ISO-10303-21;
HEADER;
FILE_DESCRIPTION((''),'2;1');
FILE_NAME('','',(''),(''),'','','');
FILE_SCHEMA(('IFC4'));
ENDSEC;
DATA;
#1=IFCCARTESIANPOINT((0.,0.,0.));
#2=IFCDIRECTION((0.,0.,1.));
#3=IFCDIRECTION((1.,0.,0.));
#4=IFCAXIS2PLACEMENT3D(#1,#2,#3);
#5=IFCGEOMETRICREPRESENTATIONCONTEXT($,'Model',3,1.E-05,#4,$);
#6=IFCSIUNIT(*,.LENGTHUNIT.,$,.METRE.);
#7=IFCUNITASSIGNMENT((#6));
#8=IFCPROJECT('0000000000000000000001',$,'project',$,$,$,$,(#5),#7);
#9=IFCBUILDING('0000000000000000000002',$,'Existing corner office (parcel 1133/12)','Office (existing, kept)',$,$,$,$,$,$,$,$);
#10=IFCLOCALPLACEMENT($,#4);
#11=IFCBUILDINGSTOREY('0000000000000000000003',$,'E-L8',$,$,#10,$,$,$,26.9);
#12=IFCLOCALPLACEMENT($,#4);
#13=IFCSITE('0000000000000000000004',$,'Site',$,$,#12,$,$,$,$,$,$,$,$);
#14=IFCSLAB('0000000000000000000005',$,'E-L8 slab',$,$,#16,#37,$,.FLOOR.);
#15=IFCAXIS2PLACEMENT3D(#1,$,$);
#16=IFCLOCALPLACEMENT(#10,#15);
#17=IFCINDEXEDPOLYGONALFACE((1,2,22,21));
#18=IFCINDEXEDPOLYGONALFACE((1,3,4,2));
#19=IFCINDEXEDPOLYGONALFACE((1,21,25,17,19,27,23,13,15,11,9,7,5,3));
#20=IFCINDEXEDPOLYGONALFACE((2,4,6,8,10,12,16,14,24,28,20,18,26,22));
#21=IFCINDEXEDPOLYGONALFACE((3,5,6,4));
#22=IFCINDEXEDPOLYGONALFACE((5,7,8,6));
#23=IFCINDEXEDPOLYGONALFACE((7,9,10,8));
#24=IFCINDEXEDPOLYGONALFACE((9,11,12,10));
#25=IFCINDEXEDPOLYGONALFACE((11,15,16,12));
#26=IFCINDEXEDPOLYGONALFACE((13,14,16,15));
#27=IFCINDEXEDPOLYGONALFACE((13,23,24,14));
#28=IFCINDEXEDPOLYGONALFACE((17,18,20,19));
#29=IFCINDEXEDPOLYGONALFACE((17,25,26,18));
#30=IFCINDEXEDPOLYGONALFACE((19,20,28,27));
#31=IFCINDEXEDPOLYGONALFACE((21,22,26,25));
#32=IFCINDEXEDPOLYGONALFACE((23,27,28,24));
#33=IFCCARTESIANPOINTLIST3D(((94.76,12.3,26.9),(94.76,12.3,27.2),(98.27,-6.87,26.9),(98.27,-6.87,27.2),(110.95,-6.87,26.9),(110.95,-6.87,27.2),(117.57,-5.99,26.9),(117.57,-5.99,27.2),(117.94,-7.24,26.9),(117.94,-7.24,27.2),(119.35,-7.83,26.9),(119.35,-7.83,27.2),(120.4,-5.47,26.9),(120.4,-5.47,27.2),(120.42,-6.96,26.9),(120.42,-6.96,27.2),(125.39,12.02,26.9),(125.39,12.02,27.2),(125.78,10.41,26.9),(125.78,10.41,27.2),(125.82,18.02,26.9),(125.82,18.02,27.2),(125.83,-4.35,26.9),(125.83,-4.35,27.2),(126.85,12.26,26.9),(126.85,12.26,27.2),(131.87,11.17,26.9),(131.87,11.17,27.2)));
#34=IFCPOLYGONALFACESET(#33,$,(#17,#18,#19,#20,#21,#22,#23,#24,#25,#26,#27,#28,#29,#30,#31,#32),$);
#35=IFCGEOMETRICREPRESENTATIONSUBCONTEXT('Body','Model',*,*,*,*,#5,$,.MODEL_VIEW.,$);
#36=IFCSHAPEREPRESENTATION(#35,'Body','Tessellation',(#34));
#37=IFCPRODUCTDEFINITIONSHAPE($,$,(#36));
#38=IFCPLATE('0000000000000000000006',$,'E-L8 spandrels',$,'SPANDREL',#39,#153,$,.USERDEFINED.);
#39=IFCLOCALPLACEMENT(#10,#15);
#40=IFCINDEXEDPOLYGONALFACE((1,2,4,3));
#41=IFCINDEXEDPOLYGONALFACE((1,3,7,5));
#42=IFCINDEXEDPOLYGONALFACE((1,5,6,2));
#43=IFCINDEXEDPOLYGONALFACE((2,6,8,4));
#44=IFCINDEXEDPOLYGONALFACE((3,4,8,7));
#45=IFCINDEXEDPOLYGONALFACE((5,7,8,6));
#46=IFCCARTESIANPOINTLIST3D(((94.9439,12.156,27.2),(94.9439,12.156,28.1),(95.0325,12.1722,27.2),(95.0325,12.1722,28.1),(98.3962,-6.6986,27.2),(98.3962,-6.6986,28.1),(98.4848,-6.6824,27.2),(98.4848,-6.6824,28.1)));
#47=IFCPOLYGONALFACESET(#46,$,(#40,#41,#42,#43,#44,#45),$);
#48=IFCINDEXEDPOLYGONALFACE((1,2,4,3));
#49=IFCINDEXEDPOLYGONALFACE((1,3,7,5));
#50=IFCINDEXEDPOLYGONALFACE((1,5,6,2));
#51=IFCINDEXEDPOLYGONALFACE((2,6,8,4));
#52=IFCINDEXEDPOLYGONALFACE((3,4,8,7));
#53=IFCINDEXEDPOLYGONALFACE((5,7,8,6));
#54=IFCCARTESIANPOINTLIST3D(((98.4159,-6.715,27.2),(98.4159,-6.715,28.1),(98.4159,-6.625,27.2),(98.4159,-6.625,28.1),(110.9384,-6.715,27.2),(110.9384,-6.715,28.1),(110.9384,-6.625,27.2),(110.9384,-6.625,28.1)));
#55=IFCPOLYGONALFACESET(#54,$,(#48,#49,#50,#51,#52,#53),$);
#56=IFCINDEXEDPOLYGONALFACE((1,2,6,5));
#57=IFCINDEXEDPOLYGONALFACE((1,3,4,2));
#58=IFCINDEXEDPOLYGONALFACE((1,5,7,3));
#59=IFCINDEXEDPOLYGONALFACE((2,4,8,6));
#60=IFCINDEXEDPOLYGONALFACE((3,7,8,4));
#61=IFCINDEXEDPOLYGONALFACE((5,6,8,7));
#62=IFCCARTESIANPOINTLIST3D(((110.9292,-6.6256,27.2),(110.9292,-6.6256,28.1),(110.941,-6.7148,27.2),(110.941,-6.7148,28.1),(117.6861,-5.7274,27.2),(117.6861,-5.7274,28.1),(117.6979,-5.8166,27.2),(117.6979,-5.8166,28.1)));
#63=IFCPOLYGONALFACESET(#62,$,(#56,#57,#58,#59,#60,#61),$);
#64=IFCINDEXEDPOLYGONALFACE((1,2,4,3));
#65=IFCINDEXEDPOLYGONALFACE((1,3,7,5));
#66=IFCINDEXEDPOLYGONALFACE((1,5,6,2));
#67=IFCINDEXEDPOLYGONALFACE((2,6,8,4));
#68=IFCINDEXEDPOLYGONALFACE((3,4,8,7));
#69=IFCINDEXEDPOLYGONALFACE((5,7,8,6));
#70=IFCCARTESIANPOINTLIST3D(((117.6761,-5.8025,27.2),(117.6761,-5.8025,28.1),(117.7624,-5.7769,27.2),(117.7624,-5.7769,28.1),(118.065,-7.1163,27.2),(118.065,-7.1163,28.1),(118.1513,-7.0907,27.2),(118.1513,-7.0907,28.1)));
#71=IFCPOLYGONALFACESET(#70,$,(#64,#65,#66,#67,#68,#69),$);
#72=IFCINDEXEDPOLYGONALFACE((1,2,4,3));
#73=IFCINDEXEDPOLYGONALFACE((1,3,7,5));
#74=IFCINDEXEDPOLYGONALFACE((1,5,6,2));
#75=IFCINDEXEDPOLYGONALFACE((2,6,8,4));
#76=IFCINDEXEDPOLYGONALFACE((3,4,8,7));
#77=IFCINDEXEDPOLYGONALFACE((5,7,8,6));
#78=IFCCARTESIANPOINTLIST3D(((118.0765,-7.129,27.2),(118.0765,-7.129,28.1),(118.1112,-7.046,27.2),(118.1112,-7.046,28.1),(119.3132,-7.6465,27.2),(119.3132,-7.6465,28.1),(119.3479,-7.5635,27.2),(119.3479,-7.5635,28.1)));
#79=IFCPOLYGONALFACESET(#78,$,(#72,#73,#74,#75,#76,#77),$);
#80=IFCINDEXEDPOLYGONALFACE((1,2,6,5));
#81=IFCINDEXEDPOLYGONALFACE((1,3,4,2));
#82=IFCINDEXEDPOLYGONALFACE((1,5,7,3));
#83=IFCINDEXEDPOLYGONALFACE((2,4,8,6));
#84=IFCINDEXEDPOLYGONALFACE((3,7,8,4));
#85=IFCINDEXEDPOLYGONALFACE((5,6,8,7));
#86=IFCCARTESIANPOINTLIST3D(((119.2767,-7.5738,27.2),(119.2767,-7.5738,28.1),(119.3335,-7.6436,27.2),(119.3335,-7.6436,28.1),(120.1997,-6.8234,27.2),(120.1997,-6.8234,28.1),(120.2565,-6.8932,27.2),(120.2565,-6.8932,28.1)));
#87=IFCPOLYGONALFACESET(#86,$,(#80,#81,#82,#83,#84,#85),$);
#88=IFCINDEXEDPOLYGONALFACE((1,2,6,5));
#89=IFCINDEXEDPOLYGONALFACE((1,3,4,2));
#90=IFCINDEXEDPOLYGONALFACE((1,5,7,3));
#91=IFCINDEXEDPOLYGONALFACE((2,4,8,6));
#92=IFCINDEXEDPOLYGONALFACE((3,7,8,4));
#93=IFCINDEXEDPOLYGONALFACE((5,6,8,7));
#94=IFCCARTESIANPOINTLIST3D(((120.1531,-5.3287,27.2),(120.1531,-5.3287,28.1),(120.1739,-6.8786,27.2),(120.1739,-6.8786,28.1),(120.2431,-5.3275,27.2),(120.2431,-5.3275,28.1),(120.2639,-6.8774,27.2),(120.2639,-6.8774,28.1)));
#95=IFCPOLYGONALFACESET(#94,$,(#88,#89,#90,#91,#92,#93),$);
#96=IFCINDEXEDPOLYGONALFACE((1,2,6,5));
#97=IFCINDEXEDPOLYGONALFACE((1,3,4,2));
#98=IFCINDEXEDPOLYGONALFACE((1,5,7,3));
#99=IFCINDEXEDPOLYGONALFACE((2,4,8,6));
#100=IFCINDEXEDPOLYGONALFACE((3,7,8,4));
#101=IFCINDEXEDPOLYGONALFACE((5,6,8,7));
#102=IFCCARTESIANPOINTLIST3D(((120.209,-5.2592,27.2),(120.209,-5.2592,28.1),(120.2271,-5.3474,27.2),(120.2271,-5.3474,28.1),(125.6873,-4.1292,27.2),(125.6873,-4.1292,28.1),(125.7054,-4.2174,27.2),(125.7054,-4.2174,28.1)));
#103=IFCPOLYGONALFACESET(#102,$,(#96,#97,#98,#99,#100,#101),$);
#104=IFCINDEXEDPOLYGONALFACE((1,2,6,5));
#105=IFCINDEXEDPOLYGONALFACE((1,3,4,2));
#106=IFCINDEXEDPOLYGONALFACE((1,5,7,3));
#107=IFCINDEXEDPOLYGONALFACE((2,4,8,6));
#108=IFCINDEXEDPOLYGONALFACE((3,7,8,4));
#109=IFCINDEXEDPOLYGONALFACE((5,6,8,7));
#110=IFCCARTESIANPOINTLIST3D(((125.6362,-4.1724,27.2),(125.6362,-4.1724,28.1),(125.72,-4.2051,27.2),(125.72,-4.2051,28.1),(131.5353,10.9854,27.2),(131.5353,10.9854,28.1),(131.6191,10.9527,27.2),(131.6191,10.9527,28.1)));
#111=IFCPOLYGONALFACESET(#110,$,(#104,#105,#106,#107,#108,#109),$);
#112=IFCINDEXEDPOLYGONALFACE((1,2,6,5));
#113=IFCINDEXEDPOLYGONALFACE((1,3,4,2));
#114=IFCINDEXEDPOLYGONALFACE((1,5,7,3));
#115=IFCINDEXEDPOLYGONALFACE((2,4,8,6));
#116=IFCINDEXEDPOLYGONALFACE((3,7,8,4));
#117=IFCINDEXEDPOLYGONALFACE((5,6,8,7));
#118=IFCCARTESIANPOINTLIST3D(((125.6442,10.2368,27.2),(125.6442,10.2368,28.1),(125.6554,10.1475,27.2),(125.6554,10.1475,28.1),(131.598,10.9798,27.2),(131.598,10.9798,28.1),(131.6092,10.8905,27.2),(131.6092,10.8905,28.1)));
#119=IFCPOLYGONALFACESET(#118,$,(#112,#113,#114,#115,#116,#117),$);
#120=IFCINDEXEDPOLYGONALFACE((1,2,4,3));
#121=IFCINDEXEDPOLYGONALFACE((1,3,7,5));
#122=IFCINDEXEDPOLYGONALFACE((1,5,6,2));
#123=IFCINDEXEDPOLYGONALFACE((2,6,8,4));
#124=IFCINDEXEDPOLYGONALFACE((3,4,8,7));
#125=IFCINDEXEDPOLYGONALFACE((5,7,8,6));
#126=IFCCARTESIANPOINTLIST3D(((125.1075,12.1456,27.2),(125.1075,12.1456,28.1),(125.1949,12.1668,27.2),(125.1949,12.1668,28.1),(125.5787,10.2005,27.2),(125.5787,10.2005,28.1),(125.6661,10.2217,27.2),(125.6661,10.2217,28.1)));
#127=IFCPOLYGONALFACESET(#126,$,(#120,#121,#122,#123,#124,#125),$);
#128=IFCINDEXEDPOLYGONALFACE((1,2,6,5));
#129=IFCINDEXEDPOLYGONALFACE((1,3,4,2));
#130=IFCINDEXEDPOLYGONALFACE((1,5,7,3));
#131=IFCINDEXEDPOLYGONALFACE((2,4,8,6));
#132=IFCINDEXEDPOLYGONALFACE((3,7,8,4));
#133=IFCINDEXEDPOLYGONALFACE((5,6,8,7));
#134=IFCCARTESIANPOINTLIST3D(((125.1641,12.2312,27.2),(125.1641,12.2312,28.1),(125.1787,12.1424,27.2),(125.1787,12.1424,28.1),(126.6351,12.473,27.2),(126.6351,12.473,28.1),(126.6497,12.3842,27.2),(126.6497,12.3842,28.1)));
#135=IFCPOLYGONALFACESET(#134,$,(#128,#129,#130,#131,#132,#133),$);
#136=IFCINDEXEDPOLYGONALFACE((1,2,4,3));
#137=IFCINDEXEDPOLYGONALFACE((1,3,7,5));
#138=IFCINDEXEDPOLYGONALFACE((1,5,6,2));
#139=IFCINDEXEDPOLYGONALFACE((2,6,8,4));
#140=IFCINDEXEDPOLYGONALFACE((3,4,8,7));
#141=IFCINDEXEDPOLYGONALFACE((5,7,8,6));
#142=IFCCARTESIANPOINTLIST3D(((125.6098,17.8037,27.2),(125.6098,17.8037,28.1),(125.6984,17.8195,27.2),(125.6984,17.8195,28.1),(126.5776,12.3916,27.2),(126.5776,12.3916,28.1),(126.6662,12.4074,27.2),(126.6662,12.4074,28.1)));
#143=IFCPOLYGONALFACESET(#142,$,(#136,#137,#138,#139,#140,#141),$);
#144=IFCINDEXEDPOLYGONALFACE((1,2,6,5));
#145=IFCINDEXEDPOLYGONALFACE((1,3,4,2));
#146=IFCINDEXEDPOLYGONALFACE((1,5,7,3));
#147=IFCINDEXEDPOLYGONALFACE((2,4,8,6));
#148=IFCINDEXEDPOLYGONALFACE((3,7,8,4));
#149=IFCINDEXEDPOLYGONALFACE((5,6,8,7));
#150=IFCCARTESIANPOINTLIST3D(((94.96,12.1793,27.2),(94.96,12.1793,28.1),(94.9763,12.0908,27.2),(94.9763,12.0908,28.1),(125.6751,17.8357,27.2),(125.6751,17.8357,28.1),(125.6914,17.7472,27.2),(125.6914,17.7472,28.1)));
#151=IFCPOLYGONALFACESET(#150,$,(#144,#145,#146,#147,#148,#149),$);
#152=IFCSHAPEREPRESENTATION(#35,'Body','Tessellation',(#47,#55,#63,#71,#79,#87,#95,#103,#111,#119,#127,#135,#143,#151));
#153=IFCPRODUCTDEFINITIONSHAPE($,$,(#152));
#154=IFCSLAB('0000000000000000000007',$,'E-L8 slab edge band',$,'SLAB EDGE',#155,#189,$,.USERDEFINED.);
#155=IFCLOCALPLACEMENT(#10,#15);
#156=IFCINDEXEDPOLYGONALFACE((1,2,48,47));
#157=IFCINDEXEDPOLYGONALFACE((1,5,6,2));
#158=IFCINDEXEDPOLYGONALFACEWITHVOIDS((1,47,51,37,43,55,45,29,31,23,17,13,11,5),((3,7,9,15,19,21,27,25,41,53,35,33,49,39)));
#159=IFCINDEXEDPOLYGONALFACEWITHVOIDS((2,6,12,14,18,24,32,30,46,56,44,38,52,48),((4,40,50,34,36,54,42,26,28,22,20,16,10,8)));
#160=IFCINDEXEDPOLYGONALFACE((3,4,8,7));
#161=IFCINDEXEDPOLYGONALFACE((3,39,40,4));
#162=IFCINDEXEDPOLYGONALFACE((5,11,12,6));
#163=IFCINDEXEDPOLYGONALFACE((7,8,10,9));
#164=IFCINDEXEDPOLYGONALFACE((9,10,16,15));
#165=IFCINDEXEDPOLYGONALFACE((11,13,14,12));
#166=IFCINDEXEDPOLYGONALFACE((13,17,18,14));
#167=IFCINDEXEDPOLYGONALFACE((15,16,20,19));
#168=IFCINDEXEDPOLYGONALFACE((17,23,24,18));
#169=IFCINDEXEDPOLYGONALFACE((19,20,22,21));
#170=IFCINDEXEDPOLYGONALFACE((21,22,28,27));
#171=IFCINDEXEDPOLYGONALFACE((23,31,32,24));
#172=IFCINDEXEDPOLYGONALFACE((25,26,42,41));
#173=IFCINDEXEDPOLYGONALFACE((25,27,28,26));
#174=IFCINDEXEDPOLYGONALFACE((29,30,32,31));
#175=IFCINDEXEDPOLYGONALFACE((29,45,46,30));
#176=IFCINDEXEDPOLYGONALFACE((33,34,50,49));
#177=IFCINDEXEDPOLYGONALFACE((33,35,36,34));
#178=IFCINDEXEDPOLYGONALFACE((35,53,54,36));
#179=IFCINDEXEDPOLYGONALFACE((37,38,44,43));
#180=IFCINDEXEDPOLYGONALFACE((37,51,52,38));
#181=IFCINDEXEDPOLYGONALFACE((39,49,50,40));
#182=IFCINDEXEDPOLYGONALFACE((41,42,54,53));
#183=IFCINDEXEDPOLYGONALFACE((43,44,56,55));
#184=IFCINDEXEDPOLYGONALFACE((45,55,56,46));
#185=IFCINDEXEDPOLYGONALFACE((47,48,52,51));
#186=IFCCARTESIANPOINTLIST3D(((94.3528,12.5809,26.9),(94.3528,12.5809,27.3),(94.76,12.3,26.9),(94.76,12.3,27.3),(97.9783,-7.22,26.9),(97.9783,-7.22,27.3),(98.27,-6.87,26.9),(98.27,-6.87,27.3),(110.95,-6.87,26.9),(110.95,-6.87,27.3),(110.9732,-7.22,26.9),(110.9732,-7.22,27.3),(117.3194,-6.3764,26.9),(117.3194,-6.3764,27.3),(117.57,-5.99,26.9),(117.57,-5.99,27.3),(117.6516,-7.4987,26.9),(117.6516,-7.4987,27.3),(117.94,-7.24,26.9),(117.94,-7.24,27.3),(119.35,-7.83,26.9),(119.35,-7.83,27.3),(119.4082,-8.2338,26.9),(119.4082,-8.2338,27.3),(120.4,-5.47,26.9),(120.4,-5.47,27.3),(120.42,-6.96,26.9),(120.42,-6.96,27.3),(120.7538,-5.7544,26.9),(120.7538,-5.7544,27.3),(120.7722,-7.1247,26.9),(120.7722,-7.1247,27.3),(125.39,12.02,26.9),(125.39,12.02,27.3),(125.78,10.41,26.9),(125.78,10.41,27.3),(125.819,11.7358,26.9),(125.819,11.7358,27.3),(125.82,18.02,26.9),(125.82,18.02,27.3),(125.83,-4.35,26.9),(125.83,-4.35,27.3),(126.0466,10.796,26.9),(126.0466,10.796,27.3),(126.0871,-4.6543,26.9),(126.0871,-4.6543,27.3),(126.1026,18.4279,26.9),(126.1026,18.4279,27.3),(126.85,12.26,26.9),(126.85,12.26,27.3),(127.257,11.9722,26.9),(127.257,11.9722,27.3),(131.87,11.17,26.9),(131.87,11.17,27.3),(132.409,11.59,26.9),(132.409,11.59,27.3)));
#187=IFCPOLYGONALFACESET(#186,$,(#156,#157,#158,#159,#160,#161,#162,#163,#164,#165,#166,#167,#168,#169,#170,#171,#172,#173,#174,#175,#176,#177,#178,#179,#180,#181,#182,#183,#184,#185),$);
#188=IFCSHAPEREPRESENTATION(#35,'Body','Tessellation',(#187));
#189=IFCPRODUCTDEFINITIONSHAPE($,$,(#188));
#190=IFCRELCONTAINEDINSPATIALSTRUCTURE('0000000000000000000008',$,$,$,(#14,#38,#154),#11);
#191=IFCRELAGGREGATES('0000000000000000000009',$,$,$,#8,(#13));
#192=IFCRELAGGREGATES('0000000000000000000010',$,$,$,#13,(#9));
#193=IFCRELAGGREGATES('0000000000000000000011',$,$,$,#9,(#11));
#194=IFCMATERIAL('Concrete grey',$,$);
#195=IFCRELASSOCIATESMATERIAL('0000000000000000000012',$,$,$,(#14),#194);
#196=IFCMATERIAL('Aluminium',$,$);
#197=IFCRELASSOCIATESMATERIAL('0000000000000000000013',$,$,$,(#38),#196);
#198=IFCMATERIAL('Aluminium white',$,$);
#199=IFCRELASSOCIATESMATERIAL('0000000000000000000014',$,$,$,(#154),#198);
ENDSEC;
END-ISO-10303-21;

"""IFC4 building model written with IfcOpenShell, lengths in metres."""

from ifc_helpers import new_model, si_unit, frame, origin_with_axes, place, context, subcontext, project, spatial, polyline, outline, extrude, material, element, save


model = new_model("IFC4")

# Units and contexts
model_context = context("Model", 3, precision=1e-05, world=origin_with_axes())
body_context = subcontext(model_context, "Body", "Model", "MODEL_VIEW")
ifc_project = project(units=[si_unit("LENGTHUNIT", "METRE")], contexts=[model_context])

# Site, building, storey
site_placement = place(None, origin_with_axes())
site = spatial("IfcSite", under=ifc_project, at=site_placement, Name="Site")
building = spatial("IfcBuilding", under=site, Name="Existing corner office (parcel 1133/12)", Description="Office (existing, kept)")
storey_placement = place(None, origin_with_axes())
storey = spatial("IfcBuildingStorey", under=building, at=storey_placement, Name="E-L8", Elevation=26.9)

# Shared definitions
ifc_material_1 = material(Name="Aluminium")

# Slab
ifc_material_2 = material(Name="Concrete grey")
slab_1_placement = place(storey_placement, origin_with_axes())
element("IfcSlab", 1, at=slab_1_placement, inside=storey, material=ifc_material_2, Name="E-L8 slab", PredefinedType="FLOOR", context=body_context, shape_type="SweptSolid", body=[
    extrude(outline(polyline([(94.76, 12.3), (98.27, -6.87), (110.95, -6.87), (117.57, -5.99), (117.94, -7.24), (119.35, -7.83), (120.42, -6.96), (120.4, -5.47), (125.83, -4.35), (131.87, 11.17), (125.78, 10.41), (125.39, 12.02), (126.85, 12.26), (125.82, 18.02), (94.76, 12.3)])), frame((0.0, 0.0, 26.9), z_axis=(0.0, 0.0, 1.0), x_axis=(1.0, 0.0, 0.0)), (0.0, 0.0, 1.0), 0.3),
])

# Plate
plate_placement = place(storey_placement, origin_with_axes())
element("IfcPlate", 2, at=plate_placement, inside=storey, material=ifc_material_1, Name="E-L8 spandrels", ObjectType="SPANDREL", PredefinedType="USERDEFINED", context=body_context, shape_type="SweptSolid", body=[
    extrude(outline(polyline([(94.9439, 12.156), (98.3962, -6.6986), (98.4848, -6.6824), (95.0325, 12.1722), (94.9439, 12.156)])), frame((0.0, 0.0, 27.2), z_axis=(0.0, 0.0, 1.0), x_axis=(1.0, 0.0, 0.0)), (0.0, 0.0, 1.0), 0.9),
    extrude(outline(polyline([(98.4159, -6.715), (110.9384, -6.715), (110.9384, -6.625), (98.4159, -6.625), (98.4159, -6.715)])), frame((0.0, 0.0, 27.2), z_axis=(0.0, 0.0, 1.0), x_axis=(1.0, 0.0, 0.0)), (0.0, 0.0, 1.0), 0.9),
    extrude(outline(polyline([(110.941, -6.7148), (117.6979, -5.8166), (117.6861, -5.7274), (110.9292, -6.6256), (110.941, -6.7148)])), frame((0.0, 0.0, 27.2), z_axis=(0.0, 0.0, 1.0), x_axis=(1.0, 0.0, 0.0)), (0.0, 0.0, 1.0), 0.9),
    extrude(outline(polyline([(117.6761, -5.8025), (118.065, -7.1163), (118.1513, -7.0907), (117.7624, -5.7769), (117.6761, -5.8025)])), frame((0.0, 0.0, 27.2), z_axis=(0.0, 0.0, 1.0), x_axis=(1.0, 0.0, 0.0)), (0.0, 0.0, 1.0), 0.9),
    extrude(outline(polyline([(118.0765, -7.129), (119.3132, -7.6465), (119.3479, -7.5635), (118.1112, -7.046), (118.0765, -7.129)])), frame((0.0, 0.0, 27.2), z_axis=(0.0, 0.0, 1.0), x_axis=(1.0, 0.0, 0.0)), (0.0, 0.0, 1.0), 0.9),
    extrude(outline(polyline([(119.3335, -7.6436), (120.2565, -6.8932), (120.1997, -6.8234), (119.2767, -7.5738), (119.3335, -7.6436)])), frame((0.0, 0.0, 27.2), z_axis=(0.0, 0.0, 1.0), x_axis=(1.0, 0.0, 0.0)), (0.0, 0.0, 1.0), 0.9),
    extrude(outline(polyline([(120.2639, -6.8774), (120.2431, -5.3275), (120.1531, -5.3287), (120.1739, -6.8786), (120.2639, -6.8774)])), frame((0.0, 0.0, 27.2), z_axis=(0.0, 0.0, 1.0), x_axis=(1.0, 0.0, 0.0)), (0.0, 0.0, 1.0), 0.9),
    extrude(outline(polyline([(120.2271, -5.3474), (125.7054, -4.2174), (125.6873, -4.1292), (120.209, -5.2592), (120.2271, -5.3474)])), frame((0.0, 0.0, 27.2), z_axis=(0.0, 0.0, 1.0), x_axis=(1.0, 0.0, 0.0)), (0.0, 0.0, 1.0), 0.9),
    extrude(outline(polyline([(125.72, -4.2051), (131.6191, 10.9527), (131.5353, 10.9854), (125.6362, -4.1724), (125.72, -4.2051)])), frame((0.0, 0.0, 27.2), z_axis=(0.0, 0.0, 1.0), x_axis=(1.0, 0.0, 0.0)), (0.0, 0.0, 1.0), 0.9),
    extrude(outline(polyline([(131.598, 10.9798), (125.6442, 10.2368), (125.6554, 10.1475), (131.6092, 10.8905), (131.598, 10.9798)])), frame((0.0, 0.0, 27.2), z_axis=(0.0, 0.0, 1.0), x_axis=(1.0, 0.0, 0.0)), (0.0, 0.0, 1.0), 0.9),
    extrude(outline(polyline([(125.6661, 10.2217), (125.1949, 12.1668), (125.1075, 12.1456), (125.5787, 10.2005), (125.6661, 10.2217)])), frame((0.0, 0.0, 27.2), z_axis=(0.0, 0.0, 1.0), x_axis=(1.0, 0.0, 0.0)), (0.0, 0.0, 1.0), 0.9),
    extrude(outline(polyline([(125.1787, 12.1424), (126.6497, 12.3842), (126.6351, 12.473), (125.1641, 12.2312), (125.1787, 12.1424)])), frame((0.0, 0.0, 27.2), z_axis=(0.0, 0.0, 1.0), x_axis=(1.0, 0.0, 0.0)), (0.0, 0.0, 1.0), 0.9),
    extrude(outline(polyline([(126.6662, 12.4074), (125.6984, 17.8195), (125.6098, 17.8037), (126.5776, 12.3916), (126.6662, 12.4074)])), frame((0.0, 0.0, 27.2), z_axis=(0.0, 0.0, 1.0), x_axis=(1.0, 0.0, 0.0)), (0.0, 0.0, 1.0), 0.9),
    extrude(outline(polyline([(125.6751, 17.8357), (94.96, 12.1793), (94.9763, 12.0908), (125.6914, 17.7472), (125.6751, 17.8357)])), frame((0.0, 0.0, 27.2), z_axis=(0.0, 0.0, 1.0), x_axis=(1.0, 0.0, 0.0)), (0.0, 0.0, 1.0), 0.9),
])

# Slab
ifc_material_3 = material(Name="Aluminium white")
slab_2_placement = place(storey_placement, origin_with_axes())
element("IfcSlab", 3, at=slab_2_placement, inside=storey, material=ifc_material_3, Name="E-L8 slab edge band", ObjectType="SLAB EDGE", PredefinedType="USERDEFINED", context=body_context, shape_type="SweptSolid", body=[
    extrude(outline(polyline([(94.3528, 12.5809), (97.9783, -7.22), (110.9732, -7.22), (117.3194, -6.3764), (117.6516, -7.4987), (119.4082, -8.2338), (120.7722, -7.1247), (120.7538, -5.7544), (126.0871, -4.6543), (132.409, 11.59), (126.0466, 10.796), (125.819, 11.7358), (127.257, 11.9722), (126.1026, 18.4279), (94.3528, 12.5809)]), holes=[polyline([(94.76, 12.3), (98.27, -6.87), (110.95, -6.87), (117.57, -5.99), (117.94, -7.24), (119.35, -7.83), (120.42, -6.96), (120.4, -5.47), (125.83, -4.35), (131.87, 11.17), (125.78, 10.41), (125.39, 12.02), (126.85, 12.26), (125.82, 18.02), (94.76, 12.3)])]), frame((0.0, 0.0, 26.9), z_axis=(0.0, 0.0, 1.0), x_axis=(1.0, 0.0, 0.0)), (0.0, 0.0, 1.0), 0.4),
])

save(model, "model.ifc")
